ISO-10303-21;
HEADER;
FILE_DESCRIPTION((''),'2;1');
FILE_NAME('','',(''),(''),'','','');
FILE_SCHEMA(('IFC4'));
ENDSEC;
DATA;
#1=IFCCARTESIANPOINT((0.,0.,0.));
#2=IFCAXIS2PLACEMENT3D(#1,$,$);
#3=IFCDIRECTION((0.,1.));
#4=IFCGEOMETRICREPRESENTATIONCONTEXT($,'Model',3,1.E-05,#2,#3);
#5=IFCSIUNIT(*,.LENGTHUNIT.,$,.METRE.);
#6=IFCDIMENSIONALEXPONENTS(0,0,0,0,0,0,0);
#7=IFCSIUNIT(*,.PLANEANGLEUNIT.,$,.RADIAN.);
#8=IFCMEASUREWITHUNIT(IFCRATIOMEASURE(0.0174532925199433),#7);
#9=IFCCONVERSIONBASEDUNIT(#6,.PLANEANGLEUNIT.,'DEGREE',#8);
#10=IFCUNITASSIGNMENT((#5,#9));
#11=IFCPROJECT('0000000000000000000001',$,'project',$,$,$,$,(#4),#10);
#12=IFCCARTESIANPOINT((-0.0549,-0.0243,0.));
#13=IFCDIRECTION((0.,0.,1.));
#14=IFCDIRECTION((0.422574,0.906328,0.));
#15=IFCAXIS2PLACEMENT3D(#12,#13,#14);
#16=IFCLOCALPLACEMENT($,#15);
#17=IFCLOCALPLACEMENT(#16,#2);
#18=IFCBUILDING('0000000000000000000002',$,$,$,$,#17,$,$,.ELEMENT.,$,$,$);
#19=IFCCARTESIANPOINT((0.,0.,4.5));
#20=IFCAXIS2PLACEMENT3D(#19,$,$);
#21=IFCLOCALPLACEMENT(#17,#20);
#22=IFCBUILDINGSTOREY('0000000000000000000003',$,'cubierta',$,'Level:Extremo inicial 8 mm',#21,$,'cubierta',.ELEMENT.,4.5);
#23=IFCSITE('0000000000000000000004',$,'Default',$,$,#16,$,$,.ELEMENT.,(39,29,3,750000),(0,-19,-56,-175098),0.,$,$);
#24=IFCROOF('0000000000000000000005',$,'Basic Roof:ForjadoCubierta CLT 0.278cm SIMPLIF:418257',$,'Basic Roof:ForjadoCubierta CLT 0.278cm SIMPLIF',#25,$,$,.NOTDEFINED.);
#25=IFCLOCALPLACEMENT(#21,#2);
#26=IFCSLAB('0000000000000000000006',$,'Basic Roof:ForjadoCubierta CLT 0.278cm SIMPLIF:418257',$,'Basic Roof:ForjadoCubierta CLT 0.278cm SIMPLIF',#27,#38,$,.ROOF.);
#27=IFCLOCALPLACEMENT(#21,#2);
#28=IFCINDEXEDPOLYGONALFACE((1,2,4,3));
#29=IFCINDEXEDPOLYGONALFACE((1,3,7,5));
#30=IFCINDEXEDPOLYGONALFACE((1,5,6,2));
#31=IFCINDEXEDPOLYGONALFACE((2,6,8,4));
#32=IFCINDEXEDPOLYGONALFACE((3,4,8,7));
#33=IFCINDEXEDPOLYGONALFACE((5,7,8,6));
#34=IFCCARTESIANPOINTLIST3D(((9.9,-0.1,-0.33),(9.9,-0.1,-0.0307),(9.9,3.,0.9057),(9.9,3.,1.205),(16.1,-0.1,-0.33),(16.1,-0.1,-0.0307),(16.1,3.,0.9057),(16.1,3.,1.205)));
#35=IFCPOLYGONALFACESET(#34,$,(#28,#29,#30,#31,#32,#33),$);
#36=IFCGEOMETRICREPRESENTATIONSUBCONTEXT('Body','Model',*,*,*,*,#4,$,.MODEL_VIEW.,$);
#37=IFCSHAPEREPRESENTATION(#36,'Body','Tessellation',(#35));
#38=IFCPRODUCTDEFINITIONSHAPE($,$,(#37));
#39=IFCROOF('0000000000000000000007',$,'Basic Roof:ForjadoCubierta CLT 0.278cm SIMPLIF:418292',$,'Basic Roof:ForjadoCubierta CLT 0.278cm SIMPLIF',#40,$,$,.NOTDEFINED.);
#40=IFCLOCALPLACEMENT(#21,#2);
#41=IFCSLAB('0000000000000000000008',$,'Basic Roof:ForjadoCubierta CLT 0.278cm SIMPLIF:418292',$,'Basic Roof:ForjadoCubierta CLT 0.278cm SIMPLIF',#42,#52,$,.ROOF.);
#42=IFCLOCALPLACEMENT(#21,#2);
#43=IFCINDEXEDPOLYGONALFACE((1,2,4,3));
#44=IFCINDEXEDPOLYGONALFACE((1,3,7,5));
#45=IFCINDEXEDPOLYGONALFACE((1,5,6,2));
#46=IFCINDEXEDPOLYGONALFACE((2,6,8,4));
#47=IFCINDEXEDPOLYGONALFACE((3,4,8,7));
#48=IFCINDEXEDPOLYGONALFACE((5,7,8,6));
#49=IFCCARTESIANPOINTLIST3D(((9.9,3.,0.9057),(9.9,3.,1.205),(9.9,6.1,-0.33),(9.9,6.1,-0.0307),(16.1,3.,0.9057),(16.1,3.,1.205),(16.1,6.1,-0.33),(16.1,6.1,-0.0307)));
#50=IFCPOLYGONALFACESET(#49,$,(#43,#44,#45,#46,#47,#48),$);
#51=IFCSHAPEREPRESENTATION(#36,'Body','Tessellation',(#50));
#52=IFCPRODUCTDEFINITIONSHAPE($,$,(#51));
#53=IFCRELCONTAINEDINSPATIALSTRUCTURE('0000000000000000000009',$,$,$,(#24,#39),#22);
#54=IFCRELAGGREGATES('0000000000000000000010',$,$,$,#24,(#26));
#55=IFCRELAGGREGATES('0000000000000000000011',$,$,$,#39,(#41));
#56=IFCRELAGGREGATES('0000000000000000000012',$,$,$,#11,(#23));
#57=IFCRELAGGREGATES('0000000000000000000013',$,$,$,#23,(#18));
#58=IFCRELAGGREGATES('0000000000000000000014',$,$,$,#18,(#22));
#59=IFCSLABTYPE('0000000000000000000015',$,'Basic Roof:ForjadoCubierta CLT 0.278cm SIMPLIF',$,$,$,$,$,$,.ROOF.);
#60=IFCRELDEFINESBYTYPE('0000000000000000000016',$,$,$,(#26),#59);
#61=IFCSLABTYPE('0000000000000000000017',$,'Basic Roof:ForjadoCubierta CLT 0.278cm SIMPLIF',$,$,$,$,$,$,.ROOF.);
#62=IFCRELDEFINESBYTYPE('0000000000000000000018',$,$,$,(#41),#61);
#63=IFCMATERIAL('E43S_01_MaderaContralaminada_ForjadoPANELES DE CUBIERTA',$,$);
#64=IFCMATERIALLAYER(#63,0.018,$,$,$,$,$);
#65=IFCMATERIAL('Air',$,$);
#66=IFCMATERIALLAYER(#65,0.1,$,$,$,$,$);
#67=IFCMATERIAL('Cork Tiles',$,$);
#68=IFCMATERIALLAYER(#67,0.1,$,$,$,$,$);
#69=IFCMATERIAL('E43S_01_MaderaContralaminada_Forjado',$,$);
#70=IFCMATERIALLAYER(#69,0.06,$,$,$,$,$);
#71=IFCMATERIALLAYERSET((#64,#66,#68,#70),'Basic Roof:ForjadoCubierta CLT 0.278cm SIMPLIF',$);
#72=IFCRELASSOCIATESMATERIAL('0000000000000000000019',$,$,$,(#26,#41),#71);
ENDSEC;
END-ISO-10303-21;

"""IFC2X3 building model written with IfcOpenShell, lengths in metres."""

from ifc_helpers import new_model, entity, si_unit, converted_unit, direction, frame, frame_2d, origin, place, context, subcontext, project, spatial, rectangle, extrude, material, layer, layer_set, type_object, element, aggregate, save


model = new_model("IFC2X3")

# Units and contexts
model_context = context("Model", 3, precision=1e-05, world=origin(), true_north=direction((0.0, 1.0)))
body_context = subcontext(model_context, "Body", "Model", "MODEL_VIEW")
ifc_project = project(units=[si_unit("LENGTHUNIT", "METRE"), converted_unit("PLANEANGLEUNIT", "DEGREE", entity("IfcRatioMeasure", 0.0174532925199433), si_unit("PLANEANGLEUNIT", "RADIAN"), dimensions=[0, 0, 0, 0, 0, 0, 0])], contexts=[model_context])

# Site, building, storey
site_placement = place(None, frame((-0.0549, -0.0243, 0.0), z_axis=(0.0, 0.0, 1.0), x_axis=(0.422574, 0.906328, 0.0)))
site = spatial("IfcSite", under=ifc_project, at=site_placement, Name="Default", CompositionType="ELEMENT", RefLatitude=(39, 29, 3, 750000), RefLongitude=(0, -19, -56, -175098), RefElevation=0.0)
building_placement = place(site_placement, origin())
building = spatial("IfcBuilding", under=site, at=building_placement, CompositionType="ELEMENT")
storey_placement = place(building_placement, frame((0.0, 0.0, 4.5)))
storey = spatial("IfcBuildingStorey", under=building, at=storey_placement, Name="cubierta", ObjectType="Level:Extremo inicial 8 mm", LongName="cubierta", CompositionType="ELEMENT", Elevation=4.5)

# Roofs, slabs
roof_1_placement = place(storey_placement, frame((9.9, -0.1, -0.33)))
roof_1 = element("IfcRoof", 1, at=roof_1_placement, inside=storey, Name="Basic Roof:ForjadoCubierta CLT 0.278cm SIMPLIF:418257", ObjectType="Basic Roof:ForjadoCubierta CLT 0.278cm SIMPLIF", ShapeType="NOTDEFINED")
ifc_material_1 = material(Name="E43S_01_MaderaContralaminada_ForjadoPANELES DE CUBIERTA")
ifc_layer_1 = layer(ifc_material_1, 0.018)
ifc_material_2 = material(Name="Air")
ifc_layer_2 = layer(ifc_material_2, 0.1)
ifc_material_3 = material(Name="Cork Tiles")
ifc_layer_3 = layer(ifc_material_3, 0.1)
ifc_material_4 = material(Name="E43S_01_MaderaContralaminada_Forjado")
ifc_layer_4 = layer(ifc_material_4, 0.06)
ifc_layer_set = layer_set([ifc_layer_1, ifc_layer_2, ifc_layer_3, ifc_layer_4], Name="Basic Roof:ForjadoCubierta CLT 0.278cm SIMPLIF")
slab_type_1 = type_object("IfcSlabType", Name="Basic Roof:ForjadoCubierta CLT 0.278cm SIMPLIF", PredefinedType="ROOF")
slab_1_placement = place(roof_1_placement, origin())
slab_1 = element("IfcSlab", 2, at=slab_1_placement, type_object=slab_type_1, material=ifc_layer_set, Name="Basic Roof:ForjadoCubierta CLT 0.278cm SIMPLIF:418257", ObjectType="Basic Roof:ForjadoCubierta CLT 0.278cm SIMPLIF", PredefinedType="ROOF", context=body_context, shape_type="SweptSolid", body=[
    extrude(rectangle(XDim=3.3372, YDim=6.2, at=frame_2d((0.0, 0.0), x_axis=(0.0, -1.0))), frame((3.1, 1.55, 0.6179), z_axis=(0.0, -0.370288, 0.928917), x_axis=(1.0, 0.0, 0.0)), (0.0, 0.370288, 0.928917), 0.2993),
])
aggregate(roof_1, [slab_1])
roof_2_placement = place(storey_placement, frame((9.9, 3.0, -0.33)))
roof_2 = element("IfcRoof", 3, at=roof_2_placement, inside=storey, Name="Basic Roof:ForjadoCubierta CLT 0.278cm SIMPLIF:418292", ObjectType="Basic Roof:ForjadoCubierta CLT 0.278cm SIMPLIF", ShapeType="NOTDEFINED")
slab_type_2 = type_object("IfcSlabType", Name="Basic Roof:ForjadoCubierta CLT 0.278cm SIMPLIF", PredefinedType="ROOF")
slab_2_placement = place(roof_2_placement, origin())
slab_2 = element("IfcSlab", 4, at=slab_2_placement, type_object=slab_type_2, material=ifc_layer_set, Name="Basic Roof:ForjadoCubierta CLT 0.278cm SIMPLIF:418292", ObjectType="Basic Roof:ForjadoCubierta CLT 0.278cm SIMPLIF", PredefinedType="ROOF", context=body_context, shape_type="SweptSolid", body=[
    extrude(rectangle(XDim=3.3372, YDim=6.2, at=frame_2d((0.0, 0.0), x_axis=(0.0, 1.0))), frame((3.1, 1.55, 0.6179), z_axis=(0.0, 0.370288, 0.928917), x_axis=(1.0, 0.0, 0.0)), (0.0, -0.370288, 0.928917), 0.2993),
])
aggregate(roof_2, [slab_2])

save(model, "model.ifc")
